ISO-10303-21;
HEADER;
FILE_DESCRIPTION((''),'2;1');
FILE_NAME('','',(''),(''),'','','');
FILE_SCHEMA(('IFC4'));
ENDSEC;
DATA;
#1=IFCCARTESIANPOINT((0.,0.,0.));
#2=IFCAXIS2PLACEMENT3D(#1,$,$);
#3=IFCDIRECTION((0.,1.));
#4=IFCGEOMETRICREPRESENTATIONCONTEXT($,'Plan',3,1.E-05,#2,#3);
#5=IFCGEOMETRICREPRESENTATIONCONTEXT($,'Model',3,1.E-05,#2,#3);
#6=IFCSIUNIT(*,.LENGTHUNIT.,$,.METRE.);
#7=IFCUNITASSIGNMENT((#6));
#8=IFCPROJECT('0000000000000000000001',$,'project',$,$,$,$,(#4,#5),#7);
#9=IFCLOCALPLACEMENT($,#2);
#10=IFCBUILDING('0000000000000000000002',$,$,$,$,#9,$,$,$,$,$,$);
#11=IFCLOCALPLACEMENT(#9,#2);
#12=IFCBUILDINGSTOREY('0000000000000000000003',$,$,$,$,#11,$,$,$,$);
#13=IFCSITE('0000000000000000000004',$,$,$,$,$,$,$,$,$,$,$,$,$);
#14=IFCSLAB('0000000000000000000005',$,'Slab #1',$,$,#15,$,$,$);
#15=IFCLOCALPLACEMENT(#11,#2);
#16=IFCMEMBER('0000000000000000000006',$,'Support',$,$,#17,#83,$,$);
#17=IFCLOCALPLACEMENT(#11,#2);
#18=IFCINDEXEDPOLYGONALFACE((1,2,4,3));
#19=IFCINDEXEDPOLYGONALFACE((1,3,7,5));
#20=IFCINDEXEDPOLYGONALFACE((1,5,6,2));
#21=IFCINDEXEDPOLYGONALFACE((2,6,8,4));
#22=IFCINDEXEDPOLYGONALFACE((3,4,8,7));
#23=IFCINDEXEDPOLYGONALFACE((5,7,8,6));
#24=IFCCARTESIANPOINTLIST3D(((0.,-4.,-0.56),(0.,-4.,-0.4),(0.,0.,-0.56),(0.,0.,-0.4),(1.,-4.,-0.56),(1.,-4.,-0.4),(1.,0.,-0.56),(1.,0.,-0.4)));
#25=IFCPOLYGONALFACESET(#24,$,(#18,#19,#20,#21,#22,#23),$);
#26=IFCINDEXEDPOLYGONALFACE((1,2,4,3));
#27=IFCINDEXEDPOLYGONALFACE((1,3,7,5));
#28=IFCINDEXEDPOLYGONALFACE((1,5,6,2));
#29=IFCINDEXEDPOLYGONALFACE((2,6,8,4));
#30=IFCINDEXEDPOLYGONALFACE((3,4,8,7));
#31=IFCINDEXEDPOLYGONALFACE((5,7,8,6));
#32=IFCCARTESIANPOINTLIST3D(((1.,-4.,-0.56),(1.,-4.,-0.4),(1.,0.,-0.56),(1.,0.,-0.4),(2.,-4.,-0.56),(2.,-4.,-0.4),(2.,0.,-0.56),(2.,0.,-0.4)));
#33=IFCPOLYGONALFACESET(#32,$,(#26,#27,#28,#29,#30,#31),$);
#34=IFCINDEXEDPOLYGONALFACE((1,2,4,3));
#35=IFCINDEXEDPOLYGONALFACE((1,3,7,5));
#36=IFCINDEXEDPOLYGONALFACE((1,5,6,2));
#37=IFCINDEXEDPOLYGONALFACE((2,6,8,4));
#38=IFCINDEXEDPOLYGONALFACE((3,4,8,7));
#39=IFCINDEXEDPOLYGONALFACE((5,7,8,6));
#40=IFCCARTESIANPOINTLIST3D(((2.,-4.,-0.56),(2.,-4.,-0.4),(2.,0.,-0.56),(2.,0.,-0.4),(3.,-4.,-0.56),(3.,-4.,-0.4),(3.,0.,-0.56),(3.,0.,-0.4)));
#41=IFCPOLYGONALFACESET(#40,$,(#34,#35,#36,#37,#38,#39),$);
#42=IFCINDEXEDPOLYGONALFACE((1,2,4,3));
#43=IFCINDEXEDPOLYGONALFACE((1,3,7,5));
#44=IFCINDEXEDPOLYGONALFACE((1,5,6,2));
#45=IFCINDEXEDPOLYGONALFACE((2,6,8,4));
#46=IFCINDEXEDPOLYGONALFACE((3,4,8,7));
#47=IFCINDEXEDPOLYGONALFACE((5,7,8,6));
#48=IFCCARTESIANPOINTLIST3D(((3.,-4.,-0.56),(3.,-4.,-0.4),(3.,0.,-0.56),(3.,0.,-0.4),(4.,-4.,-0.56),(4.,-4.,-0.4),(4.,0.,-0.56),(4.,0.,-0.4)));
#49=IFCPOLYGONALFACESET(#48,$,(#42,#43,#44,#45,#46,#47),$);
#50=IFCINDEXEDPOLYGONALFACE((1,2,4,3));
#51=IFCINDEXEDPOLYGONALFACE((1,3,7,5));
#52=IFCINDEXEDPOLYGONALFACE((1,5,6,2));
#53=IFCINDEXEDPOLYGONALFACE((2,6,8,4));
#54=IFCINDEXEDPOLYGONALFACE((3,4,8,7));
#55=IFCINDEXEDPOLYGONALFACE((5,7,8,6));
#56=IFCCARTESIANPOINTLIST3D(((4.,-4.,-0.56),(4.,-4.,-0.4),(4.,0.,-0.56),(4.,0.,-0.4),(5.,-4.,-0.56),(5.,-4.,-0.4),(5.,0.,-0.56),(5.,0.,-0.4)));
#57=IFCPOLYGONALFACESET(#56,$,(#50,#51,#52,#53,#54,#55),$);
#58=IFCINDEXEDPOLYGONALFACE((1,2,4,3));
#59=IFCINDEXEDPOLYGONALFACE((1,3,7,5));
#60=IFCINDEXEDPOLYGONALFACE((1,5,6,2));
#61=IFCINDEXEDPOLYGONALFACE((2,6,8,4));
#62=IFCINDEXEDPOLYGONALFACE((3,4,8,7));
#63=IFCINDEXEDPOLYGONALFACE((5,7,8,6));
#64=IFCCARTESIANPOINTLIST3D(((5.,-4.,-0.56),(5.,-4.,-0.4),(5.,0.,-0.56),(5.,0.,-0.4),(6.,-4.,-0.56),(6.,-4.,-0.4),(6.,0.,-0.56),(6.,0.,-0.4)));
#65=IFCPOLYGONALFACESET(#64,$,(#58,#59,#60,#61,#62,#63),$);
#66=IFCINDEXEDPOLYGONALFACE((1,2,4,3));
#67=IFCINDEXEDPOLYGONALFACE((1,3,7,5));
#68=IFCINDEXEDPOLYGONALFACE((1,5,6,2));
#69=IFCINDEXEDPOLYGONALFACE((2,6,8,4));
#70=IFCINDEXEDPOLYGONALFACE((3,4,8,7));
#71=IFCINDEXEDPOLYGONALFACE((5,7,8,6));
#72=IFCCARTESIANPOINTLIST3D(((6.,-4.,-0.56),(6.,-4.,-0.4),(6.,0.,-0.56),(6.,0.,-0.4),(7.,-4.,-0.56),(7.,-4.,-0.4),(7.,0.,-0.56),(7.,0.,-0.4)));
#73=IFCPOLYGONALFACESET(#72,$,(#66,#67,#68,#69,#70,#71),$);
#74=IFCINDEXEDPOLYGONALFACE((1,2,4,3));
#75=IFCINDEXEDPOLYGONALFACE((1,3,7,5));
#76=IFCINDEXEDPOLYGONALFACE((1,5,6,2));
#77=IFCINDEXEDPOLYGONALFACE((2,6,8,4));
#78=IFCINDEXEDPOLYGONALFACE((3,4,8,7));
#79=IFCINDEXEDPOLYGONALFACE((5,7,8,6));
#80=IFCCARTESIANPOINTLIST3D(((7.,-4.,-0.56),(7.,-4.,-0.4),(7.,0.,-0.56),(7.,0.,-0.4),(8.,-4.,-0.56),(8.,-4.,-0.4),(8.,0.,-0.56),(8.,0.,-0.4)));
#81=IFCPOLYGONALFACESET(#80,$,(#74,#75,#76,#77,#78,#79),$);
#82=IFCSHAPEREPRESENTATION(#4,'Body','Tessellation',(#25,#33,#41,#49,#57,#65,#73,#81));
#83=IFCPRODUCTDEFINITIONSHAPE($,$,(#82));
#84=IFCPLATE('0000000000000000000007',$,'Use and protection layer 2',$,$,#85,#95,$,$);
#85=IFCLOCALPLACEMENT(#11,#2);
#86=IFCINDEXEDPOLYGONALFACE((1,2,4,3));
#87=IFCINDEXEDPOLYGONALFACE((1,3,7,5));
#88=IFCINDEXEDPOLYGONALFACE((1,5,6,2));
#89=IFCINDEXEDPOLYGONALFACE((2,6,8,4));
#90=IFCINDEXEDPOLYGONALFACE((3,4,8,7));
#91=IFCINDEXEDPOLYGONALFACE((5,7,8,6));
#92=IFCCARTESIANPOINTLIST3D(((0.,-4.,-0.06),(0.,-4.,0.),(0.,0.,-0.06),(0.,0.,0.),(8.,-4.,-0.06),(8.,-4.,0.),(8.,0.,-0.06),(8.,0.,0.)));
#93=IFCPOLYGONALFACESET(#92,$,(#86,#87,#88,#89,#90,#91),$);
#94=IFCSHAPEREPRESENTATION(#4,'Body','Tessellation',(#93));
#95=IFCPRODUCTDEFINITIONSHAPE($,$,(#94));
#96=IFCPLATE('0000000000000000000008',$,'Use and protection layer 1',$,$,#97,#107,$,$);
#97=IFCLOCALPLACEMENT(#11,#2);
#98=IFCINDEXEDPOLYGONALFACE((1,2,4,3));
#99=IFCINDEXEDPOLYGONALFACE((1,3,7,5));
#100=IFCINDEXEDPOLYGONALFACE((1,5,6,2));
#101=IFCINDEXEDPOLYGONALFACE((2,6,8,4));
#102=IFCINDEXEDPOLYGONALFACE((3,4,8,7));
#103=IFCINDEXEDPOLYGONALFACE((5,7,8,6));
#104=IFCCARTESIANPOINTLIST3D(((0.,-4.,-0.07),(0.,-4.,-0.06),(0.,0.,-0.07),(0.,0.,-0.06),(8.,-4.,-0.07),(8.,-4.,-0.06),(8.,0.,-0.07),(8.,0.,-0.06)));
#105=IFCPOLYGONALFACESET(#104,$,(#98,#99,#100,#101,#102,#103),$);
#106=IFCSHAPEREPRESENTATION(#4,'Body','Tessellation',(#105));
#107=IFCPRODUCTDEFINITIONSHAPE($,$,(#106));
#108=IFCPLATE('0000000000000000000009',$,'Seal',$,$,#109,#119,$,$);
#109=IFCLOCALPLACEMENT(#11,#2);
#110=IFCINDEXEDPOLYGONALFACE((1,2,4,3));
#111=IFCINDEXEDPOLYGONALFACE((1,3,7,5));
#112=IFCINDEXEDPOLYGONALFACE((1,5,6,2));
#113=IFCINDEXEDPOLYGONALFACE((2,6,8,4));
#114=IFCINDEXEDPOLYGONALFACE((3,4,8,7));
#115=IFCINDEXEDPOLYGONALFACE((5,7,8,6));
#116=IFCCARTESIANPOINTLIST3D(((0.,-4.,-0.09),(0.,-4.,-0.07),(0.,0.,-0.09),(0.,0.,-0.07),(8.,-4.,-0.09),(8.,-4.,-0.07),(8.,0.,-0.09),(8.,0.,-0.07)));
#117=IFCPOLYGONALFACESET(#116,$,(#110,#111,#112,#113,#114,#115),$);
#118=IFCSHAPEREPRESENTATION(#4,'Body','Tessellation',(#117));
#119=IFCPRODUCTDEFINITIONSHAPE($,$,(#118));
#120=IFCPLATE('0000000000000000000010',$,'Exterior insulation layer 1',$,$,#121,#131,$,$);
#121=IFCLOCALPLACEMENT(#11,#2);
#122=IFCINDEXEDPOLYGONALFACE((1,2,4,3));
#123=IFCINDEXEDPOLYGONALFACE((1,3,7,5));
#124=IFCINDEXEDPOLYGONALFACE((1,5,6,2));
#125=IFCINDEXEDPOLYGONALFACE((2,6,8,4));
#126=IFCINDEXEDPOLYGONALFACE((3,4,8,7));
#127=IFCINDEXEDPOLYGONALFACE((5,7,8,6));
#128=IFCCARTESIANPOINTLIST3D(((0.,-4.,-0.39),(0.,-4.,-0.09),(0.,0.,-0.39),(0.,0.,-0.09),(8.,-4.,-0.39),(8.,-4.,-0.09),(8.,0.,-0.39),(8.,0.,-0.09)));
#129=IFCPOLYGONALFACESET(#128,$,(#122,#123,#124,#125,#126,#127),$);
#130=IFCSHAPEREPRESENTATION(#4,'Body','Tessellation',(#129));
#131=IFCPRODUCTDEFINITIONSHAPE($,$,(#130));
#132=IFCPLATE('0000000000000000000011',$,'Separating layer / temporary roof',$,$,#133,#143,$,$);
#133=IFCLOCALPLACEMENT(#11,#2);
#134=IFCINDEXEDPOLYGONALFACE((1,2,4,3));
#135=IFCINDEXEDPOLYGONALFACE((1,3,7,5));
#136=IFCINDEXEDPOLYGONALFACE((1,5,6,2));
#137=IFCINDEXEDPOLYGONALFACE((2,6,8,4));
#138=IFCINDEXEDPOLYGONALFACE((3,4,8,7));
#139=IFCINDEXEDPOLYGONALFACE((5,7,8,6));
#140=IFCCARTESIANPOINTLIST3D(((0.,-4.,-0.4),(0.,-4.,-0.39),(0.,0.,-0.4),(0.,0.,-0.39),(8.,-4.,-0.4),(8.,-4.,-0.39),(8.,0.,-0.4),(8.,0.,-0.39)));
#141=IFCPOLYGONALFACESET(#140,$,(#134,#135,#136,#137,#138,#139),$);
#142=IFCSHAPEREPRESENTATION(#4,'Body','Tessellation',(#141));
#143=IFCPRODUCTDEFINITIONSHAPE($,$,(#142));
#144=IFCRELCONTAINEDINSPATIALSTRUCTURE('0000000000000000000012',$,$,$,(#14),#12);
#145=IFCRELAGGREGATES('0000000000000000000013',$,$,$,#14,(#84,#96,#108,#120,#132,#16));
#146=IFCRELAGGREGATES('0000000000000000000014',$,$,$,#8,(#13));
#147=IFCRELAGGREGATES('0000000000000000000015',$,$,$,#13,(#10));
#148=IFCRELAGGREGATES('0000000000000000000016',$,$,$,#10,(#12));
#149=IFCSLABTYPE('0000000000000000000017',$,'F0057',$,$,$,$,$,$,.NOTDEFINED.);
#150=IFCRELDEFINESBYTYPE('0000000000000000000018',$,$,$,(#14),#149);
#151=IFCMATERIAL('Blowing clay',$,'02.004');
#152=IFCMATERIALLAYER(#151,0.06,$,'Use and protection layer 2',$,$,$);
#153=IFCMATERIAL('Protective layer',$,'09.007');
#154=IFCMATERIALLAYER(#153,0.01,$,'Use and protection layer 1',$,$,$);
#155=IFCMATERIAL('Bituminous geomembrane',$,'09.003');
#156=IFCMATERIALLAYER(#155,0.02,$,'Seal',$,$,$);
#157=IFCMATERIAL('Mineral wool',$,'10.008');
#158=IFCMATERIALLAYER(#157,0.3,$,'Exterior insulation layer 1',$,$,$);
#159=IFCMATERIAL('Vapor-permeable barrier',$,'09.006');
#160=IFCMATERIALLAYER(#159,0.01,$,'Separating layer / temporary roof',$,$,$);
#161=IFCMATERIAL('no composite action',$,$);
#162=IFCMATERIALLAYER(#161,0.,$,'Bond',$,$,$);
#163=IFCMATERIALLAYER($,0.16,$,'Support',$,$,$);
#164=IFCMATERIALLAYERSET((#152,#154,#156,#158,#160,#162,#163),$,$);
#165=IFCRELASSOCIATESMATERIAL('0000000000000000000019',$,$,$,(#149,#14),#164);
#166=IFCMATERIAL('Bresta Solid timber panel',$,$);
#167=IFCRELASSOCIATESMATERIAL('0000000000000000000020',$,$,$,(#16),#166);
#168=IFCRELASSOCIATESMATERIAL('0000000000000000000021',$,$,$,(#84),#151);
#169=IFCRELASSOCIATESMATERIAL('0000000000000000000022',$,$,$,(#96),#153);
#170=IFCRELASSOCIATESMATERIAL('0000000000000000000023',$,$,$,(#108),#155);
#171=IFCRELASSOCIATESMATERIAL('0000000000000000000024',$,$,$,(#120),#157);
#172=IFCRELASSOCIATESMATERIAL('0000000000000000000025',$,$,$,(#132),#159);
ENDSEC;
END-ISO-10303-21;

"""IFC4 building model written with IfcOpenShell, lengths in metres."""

from ifc_helpers import new_model, si_unit, direction, frame, frame_2d, origin, origin_with_axes, place, context, project, spatial, rectangle, extrude, material, layer, layer_set, type_object, element, aggregate, save


model = new_model("IFC4")

# Units and contexts
plan_context = context("Plan", 3, precision=1e-05, world=origin(), true_north=direction((0.0, 1.0)))
model_context = context("Model", 3, precision=1e-05, world=origin(), true_north=direction((0.0, 1.0)))
ifc_project = project(units=[si_unit("LENGTHUNIT", "METRE")], contexts=[plan_context, model_context])

# Site, building, storey
site = spatial("IfcSite", under=ifc_project)
building_placement = place(None, origin())
building = spatial("IfcBuilding", under=site, at=building_placement)
storey_placement = place(building_placement, origin())
storey = spatial("IfcBuildingStorey", under=building, at=storey_placement)

# Slab, member, plates
ifc_material_1 = material(Name="Blowing clay", Category="02.004")
ifc_layer_1 = layer(ifc_material_1, 0.06, Name="Use and protection layer 2")
ifc_material_2 = material(Name="Protective layer", Category="09.007")
ifc_layer_2 = layer(ifc_material_2, 0.01, Name="Use and protection layer 1")
ifc_material_3 = material(Name="Bituminous geomembrane", Category="09.003")
ifc_layer_3 = layer(ifc_material_3, 0.02, Name="Seal")
ifc_material_4 = material(Name="Mineral wool", Category="10.008")
ifc_layer_4 = layer(ifc_material_4, 0.3, Name="Exterior insulation layer 1")
ifc_material_5 = material(Name="Vapor-permeable barrier", Category="09.006")
ifc_layer_5 = layer(ifc_material_5, 0.01, Name="Separating layer / temporary roof")
ifc_material_6 = material(Name="no composite action")
ifc_layer_6 = layer(ifc_material_6, 0.0, Name="Bond")
ifc_layer_7 = layer(None, 0.16, Name="Support")
ifc_layer_set = layer_set([ifc_layer_1, ifc_layer_2, ifc_layer_3, ifc_layer_4, ifc_layer_5, ifc_layer_6, ifc_layer_7])
slab_type = type_object("IfcSlabType", Name="F0057", PredefinedType="NOTDEFINED", material=ifc_layer_set)
slab_placement = place(None, frame((0.0, 0.0, 0.0), z_axis=(0.0, 0.0, -1.0), x_axis=(1.0, 0.0, 0.0)))
slab = element("IfcSlab", 1, at=slab_placement, inside=storey, type_object=slab_type, material=ifc_layer_set, Name="Slab #1")
ifc_material_7 = material(Name="Bresta Solid timber panel")
member_placement = place(slab_placement, origin())
member = element("IfcMember", 2, at=member_placement, material=ifc_material_7, Name="Support", context=plan_context, shape_type="SweptSolid", body=[
    extrude(rectangle(XDim=1.0, YDim=0.16, at=frame_2d((0.5, 0.08), x_axis=(1.0, 0.0))), frame((0.0, 4.0, 0.4), z_axis=(0.0, -1.0, 0.0), x_axis=(1.0, 0.0, 0.0)), (0.0, 0.0, 1.0), 4.0),
    extrude(rectangle(XDim=1.0, YDim=0.16, at=frame_2d((0.5, 0.08), x_axis=(1.0, 0.0))), frame((1.0, 4.0, 0.4), z_axis=(0.0, -1.0, 0.0), x_axis=(1.0, 0.0, 0.0)), (0.0, 0.0, 1.0), 4.0),
    extrude(rectangle(XDim=1.0, YDim=0.16, at=frame_2d((0.5, 0.08), x_axis=(1.0, 0.0))), frame((2.0, 4.0, 0.4), z_axis=(0.0, -1.0, 0.0), x_axis=(1.0, 0.0, 0.0)), (0.0, 0.0, 1.0), 4.0),
    extrude(rectangle(XDim=1.0, YDim=0.16, at=frame_2d((0.5, 0.08), x_axis=(1.0, 0.0))), frame((3.0, 4.0, 0.4), z_axis=(0.0, -1.0, 0.0), x_axis=(1.0, 0.0, 0.0)), (0.0, 0.0, 1.0), 4.0),
    extrude(rectangle(XDim=1.0, YDim=0.16, at=frame_2d((0.5, 0.08), x_axis=(1.0, 0.0))), frame((4.0, 4.0, 0.4), z_axis=(0.0, -1.0, 0.0), x_axis=(1.0, 0.0, 0.0)), (0.0, 0.0, 1.0), 4.0),
    extrude(rectangle(XDim=1.0, YDim=0.16, at=frame_2d((0.5, 0.08), x_axis=(1.0, 0.0))), frame((5.0, 4.0, 0.4), z_axis=(0.0, -1.0, 0.0), x_axis=(1.0, 0.0, 0.0)), (0.0, 0.0, 1.0), 4.0),
    extrude(rectangle(XDim=1.0, YDim=0.16, at=frame_2d((0.5, 0.08), x_axis=(1.0, 0.0))), frame((6.0, 4.0, 0.4), z_axis=(0.0, -1.0, 0.0), x_axis=(1.0, 0.0, 0.0)), (0.0, 0.0, 1.0), 4.0),
    extrude(rectangle(XDim=1.0, YDim=0.16, at=frame_2d((0.5, 0.08), x_axis=(1.0, 0.0))), frame((7.0, 4.0, 0.4), z_axis=(0.0, -1.0, 0.0), x_axis=(1.0, 0.0, 0.0)), (0.0, 0.0, 1.0), 4.0),
])
plate_1_placement = place(slab_placement, origin())
plate_1 = element("IfcPlate", 3, at=plate_1_placement, material=ifc_material_1, Name="Use and protection layer 2", context=plan_context, shape_type="SweptSolid", body=[
    extrude(rectangle(XDim=8.0, YDim=4.0, at=frame_2d((4.0, 2.0), x_axis=(1.0, 0.0))), origin_with_axes(), (0.0, 0.0, 1.0), 0.06),
])
plate_2_placement = place(slab_placement, origin())
plate_2 = element("IfcPlate", 4, at=plate_2_placement, material=ifc_material_2, Name="Use and protection layer 1", context=plan_context, shape_type="SweptSolid", body=[
    extrude(rectangle(XDim=8.0, YDim=4.0, at=frame_2d((4.0, 2.0), x_axis=(1.0, 0.0))), frame((0.0, 0.0, 0.06), z_axis=(0.0, 0.0, 1.0), x_axis=(1.0, 0.0, 0.0)), (0.0, 0.0, 1.0), 0.01),
])
plate_3_placement = place(slab_placement, origin())
plate_3 = element("IfcPlate", 5, at=plate_3_placement, material=ifc_material_3, Name="Seal", context=plan_context, shape_type="SweptSolid", body=[
    extrude(rectangle(XDim=8.0, YDim=4.0, at=frame_2d((4.0, 2.0), x_axis=(1.0, 0.0))), frame((0.0, 0.0, 0.07), z_axis=(0.0, 0.0, 1.0), x_axis=(1.0, 0.0, 0.0)), (0.0, 0.0, 1.0), 0.02),
])
plate_4_placement = place(slab_placement, origin())
plate_4 = element("IfcPlate", 6, at=plate_4_placement, material=ifc_material_4, Name="Exterior insulation layer 1", context=plan_context, shape_type="SweptSolid", body=[
    extrude(rectangle(XDim=8.0, YDim=4.0, at=frame_2d((4.0, 2.0), x_axis=(1.0, 0.0))), frame((0.0, 0.0, 0.09), z_axis=(0.0, 0.0, 1.0), x_axis=(1.0, 0.0, 0.0)), (0.0, 0.0, 1.0), 0.3),
])
plate_5_placement = place(slab_placement, origin())
plate_5 = element("IfcPlate", 7, at=plate_5_placement, material=ifc_material_5, Name="Separating layer / temporary roof", context=plan_context, shape_type="SweptSolid", body=[
    extrude(rectangle(XDim=8.0, YDim=4.0, at=frame_2d((4.0, 2.0), x_axis=(1.0, 0.0))), frame((0.0, 0.0, 0.39), z_axis=(0.0, 0.0, 1.0), x_axis=(1.0, 0.0, 0.0)), (0.0, 0.0, 1.0), 0.01),
])
aggregate(slab, [plate_1, plate_2, plate_3, plate_4, plate_5, member])

save(model, "model.ifc")
